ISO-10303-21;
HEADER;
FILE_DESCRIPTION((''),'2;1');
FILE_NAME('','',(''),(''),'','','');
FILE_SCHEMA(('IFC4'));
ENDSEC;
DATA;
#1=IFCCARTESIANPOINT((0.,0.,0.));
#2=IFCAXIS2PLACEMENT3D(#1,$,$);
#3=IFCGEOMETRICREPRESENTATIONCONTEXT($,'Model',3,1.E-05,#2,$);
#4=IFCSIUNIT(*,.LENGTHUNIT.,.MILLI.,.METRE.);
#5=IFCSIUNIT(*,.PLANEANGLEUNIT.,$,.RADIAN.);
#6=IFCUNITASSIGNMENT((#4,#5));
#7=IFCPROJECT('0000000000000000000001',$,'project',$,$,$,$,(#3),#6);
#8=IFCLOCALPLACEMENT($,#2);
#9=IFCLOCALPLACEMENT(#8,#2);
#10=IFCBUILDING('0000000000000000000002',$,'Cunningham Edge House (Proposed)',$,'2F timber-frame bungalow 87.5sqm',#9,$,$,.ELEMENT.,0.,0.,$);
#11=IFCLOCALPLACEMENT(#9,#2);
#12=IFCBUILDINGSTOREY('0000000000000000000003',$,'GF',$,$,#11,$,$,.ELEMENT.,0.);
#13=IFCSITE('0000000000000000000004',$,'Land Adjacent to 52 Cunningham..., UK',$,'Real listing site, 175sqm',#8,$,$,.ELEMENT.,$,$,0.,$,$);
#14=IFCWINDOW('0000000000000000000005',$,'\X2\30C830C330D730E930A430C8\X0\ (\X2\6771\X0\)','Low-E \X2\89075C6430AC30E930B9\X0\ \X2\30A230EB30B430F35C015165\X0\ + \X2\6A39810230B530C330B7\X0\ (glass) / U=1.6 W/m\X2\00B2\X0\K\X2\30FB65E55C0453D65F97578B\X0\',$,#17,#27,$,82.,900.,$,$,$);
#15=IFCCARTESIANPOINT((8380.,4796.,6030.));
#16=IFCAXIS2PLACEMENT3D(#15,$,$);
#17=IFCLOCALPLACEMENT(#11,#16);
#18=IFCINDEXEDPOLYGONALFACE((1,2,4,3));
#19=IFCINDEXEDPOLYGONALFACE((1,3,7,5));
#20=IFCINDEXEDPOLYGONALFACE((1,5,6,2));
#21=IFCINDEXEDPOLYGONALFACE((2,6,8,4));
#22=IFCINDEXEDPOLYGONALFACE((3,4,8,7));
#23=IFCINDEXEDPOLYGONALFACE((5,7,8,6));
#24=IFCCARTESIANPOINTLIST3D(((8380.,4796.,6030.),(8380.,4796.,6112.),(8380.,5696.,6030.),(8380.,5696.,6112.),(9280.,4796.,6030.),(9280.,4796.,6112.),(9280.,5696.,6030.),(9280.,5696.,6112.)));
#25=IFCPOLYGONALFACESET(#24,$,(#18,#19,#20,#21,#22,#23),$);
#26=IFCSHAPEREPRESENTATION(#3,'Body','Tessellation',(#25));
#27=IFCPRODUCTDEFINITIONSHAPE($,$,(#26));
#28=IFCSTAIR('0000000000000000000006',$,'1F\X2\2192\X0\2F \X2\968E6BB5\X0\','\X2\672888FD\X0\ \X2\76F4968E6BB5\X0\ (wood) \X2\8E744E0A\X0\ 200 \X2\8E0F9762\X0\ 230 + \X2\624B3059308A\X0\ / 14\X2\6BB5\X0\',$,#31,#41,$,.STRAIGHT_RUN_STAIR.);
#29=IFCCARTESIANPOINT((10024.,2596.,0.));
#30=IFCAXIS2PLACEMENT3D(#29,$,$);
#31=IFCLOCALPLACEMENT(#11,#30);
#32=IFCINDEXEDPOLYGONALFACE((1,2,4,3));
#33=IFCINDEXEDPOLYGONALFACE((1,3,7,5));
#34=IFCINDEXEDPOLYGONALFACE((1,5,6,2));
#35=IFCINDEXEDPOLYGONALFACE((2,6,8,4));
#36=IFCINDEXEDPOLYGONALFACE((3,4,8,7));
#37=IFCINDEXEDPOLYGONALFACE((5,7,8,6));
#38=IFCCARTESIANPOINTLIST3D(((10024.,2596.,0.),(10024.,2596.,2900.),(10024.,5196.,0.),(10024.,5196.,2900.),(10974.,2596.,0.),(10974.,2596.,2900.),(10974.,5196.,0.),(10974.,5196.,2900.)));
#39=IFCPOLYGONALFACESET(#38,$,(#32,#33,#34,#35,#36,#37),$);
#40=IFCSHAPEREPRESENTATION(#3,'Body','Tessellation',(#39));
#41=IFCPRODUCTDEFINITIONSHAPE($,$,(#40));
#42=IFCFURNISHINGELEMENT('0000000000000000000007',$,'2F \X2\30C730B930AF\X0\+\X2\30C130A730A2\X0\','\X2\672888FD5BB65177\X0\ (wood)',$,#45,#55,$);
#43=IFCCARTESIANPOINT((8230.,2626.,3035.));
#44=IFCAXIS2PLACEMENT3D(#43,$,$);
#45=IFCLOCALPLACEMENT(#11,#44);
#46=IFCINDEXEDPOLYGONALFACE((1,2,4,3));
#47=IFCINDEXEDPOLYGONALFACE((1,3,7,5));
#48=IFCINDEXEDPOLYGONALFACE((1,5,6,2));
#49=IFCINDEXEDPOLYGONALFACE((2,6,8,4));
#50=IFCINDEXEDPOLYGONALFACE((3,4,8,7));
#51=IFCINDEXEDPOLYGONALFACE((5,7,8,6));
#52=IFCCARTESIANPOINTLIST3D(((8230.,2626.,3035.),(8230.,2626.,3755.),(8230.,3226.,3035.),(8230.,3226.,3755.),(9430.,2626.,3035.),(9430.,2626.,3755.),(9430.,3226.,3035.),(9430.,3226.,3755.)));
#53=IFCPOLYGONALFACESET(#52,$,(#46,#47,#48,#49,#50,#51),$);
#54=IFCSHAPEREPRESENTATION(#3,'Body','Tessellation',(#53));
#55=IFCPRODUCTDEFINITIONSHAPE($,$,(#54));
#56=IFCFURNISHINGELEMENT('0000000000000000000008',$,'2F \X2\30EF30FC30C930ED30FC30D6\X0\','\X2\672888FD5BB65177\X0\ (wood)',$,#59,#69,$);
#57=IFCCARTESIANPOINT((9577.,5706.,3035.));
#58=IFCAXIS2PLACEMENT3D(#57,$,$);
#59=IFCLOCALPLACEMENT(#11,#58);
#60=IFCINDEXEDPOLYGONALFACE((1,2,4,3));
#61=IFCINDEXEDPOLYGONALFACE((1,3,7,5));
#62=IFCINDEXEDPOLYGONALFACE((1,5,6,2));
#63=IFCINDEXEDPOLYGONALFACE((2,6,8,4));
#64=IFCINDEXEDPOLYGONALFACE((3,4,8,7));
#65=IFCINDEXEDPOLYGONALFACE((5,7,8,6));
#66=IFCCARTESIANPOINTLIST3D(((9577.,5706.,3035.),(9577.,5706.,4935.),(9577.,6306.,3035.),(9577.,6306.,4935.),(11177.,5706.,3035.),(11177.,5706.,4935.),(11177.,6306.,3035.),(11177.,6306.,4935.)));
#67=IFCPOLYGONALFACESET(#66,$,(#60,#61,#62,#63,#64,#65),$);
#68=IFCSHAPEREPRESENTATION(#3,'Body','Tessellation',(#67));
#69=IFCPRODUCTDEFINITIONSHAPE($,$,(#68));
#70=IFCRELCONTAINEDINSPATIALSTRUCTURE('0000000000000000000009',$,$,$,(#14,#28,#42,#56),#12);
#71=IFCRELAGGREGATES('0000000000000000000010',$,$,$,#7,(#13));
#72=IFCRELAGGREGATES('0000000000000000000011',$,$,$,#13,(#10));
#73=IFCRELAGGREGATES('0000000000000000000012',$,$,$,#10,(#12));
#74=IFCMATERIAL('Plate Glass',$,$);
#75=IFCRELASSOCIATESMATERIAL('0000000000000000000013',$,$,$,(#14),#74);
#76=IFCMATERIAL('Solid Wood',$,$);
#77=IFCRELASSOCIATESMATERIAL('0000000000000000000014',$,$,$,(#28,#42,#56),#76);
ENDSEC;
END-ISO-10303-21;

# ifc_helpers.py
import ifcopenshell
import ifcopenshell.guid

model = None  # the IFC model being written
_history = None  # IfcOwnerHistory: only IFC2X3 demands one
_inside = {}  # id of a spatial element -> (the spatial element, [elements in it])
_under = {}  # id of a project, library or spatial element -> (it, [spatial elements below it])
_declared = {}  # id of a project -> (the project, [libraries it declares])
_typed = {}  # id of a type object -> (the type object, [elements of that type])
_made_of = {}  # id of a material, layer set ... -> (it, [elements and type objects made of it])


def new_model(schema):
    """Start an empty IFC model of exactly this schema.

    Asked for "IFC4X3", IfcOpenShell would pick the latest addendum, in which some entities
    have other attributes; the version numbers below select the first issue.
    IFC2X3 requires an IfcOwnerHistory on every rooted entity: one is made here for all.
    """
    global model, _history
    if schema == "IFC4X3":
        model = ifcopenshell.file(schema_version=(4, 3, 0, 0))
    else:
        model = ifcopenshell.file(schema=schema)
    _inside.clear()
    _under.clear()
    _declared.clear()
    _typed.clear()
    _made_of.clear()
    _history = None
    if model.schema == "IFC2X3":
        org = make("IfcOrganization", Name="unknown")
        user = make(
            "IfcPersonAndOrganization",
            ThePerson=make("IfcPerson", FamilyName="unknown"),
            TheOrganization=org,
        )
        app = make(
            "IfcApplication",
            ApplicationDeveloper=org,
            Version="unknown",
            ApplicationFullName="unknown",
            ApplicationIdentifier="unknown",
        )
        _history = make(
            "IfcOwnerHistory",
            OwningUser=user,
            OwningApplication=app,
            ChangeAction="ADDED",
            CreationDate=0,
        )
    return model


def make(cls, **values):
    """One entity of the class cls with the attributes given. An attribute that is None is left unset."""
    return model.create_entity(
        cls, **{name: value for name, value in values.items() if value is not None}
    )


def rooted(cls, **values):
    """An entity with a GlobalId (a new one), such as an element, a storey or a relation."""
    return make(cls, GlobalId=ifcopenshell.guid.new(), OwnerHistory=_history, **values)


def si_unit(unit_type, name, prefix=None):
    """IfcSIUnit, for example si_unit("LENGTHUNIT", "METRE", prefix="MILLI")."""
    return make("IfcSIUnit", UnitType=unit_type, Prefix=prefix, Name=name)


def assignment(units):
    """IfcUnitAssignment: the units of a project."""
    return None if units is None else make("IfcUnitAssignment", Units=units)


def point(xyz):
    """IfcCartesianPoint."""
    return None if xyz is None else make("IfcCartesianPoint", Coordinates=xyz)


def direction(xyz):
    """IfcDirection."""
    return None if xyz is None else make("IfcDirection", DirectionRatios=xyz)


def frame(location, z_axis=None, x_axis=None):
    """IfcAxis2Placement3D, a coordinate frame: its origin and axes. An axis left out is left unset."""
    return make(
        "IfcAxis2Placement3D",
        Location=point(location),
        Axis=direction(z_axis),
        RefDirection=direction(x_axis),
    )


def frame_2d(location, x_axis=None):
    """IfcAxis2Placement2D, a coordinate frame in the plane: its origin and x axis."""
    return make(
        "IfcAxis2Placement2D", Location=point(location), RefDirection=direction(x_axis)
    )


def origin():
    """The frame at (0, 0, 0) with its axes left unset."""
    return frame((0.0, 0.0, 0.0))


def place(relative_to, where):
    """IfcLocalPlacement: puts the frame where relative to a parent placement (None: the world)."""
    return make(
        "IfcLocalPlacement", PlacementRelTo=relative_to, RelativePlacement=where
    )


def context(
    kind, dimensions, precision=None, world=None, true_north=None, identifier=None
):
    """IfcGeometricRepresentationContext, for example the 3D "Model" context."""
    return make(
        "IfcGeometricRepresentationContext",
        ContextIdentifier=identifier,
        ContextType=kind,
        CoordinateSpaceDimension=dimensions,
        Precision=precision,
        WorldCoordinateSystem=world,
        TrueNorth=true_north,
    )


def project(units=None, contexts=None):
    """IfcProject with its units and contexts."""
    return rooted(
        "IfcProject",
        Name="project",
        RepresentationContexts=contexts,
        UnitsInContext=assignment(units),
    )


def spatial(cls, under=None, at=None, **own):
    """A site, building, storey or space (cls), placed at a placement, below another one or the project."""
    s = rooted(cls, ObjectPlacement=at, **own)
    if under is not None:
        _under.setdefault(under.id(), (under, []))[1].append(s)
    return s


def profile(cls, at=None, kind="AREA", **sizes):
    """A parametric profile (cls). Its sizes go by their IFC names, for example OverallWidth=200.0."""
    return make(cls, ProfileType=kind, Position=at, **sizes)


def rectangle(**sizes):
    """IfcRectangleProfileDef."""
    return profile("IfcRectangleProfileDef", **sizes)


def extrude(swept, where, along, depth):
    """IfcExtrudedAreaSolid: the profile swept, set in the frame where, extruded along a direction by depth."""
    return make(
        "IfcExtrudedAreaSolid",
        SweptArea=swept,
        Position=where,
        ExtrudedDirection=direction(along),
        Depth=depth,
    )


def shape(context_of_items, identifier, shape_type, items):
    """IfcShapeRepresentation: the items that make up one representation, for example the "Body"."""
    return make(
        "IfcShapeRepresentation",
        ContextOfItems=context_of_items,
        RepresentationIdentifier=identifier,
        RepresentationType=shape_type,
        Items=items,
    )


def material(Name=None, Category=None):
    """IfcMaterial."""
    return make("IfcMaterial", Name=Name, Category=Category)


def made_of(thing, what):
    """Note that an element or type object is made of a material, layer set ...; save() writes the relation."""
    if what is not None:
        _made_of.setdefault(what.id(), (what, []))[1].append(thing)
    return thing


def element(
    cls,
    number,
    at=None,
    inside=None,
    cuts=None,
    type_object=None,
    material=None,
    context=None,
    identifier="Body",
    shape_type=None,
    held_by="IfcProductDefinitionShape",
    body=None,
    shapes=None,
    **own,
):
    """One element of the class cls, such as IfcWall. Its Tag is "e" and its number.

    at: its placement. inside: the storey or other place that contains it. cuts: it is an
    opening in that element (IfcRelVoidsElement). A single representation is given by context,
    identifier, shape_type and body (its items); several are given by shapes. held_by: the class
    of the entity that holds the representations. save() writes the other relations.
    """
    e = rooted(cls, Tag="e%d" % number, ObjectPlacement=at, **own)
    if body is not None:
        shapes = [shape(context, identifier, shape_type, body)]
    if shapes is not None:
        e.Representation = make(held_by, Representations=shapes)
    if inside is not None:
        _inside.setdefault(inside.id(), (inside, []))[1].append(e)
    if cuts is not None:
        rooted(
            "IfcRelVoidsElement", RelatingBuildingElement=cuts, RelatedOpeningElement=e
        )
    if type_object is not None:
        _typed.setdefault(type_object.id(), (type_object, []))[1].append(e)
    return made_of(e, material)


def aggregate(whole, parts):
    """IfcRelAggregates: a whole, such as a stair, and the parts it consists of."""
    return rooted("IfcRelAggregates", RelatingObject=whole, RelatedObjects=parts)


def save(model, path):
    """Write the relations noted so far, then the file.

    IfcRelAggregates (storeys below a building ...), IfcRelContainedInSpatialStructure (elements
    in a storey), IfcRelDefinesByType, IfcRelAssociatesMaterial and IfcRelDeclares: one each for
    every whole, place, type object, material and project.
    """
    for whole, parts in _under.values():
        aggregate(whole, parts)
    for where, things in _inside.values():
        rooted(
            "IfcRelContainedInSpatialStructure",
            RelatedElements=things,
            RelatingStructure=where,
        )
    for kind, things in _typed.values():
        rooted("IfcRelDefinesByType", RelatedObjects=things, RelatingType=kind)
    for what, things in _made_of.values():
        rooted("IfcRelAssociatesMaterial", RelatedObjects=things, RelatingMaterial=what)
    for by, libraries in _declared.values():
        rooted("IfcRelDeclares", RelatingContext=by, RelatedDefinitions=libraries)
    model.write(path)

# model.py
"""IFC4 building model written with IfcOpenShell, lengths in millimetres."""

from ifc_helpers import new_model, si_unit, frame, frame_2d, origin, place, context, project, spatial, rectangle, extrude, material, element, save


model = new_model("IFC4")

# Units and contexts
model_context = context("Model", 3, precision=1e-05, world=origin())
ifc_project = project(units=[si_unit("LENGTHUNIT", "METRE", prefix="MILLI"), si_unit("PLANEANGLEUNIT", "RADIAN")], contexts=[model_context])

# Site, building, storey
site_placement = place(None, origin())
site = spatial("IfcSite", under=ifc_project, at=site_placement, Name="Land Adjacent to 52 Cunningham..., UK", ObjectType="Real listing site, 175sqm", CompositionType="ELEMENT", RefElevation=0.0)
building_placement = place(site_placement, origin())
building = spatial("IfcBuilding", under=site, at=building_placement, Name="Cunningham Edge House (Proposed)", ObjectType="2F timber-frame bungalow 87.5sqm", CompositionType="ELEMENT", ElevationOfRefHeight=0.0, ElevationOfTerrain=0.0)
storey_placement = place(building_placement, origin())
storey = spatial("IfcBuildingStorey", under=building, at=storey_placement, Name="GF", CompositionType="ELEMENT", Elevation=0.0)

# Shared definitions
ifc_material_1 = material(Name="Solid Wood")

# Shared definitions
ifc_material_2 = material(Name="Plate Glass")

# Window
window_1_placement = place(storey_placement, frame((8380.0, 4796.0, 6030.0)))
element("IfcWindow", 1, at=window_1_placement, inside=storey, material=ifc_material_2, Name="トップライト (東)", Description="Low-E 複層ガラス アルゴン封入 + 樹脂サッシ (glass) / U=1.6 W/m²K・日射取得型", OverallHeight=82.0, OverallWidth=900.0, context=model_context, shape_type="SweptSolid", body=[
    extrude(rectangle(XDim=900.0, YDim=900.0, at=frame_2d((450.0, 450.0))), frame((8380.0, 4796.0, 6030.0)), (0.0, 0.0, 1.0), 82.0),
])

# Stair
stair_placement = place(storey_placement, frame((10024.0, 2596.0, 0.0)))
element("IfcStair", 2, at=stair_placement, inside=storey, material=ifc_material_1, Name="1F→2F 階段", Description="木製 直階段 (wood) 蹴上 200 踏面 230 + 手すり / 14段", PredefinedType="STRAIGHT_RUN_STAIR", context=model_context, shape_type="SweptSolid", body=[
    extrude(rectangle(XDim=950.0, YDim=2600.0, at=frame_2d((475.0, 1300.0))), frame((10024.0, 2596.0, 0.0)), (0.0, 0.0, 1.0), 2900.0),
])

# Furnishing elements
furnishing_1_placement = place(storey_placement, frame((8230.0, 2626.0, 3035.0)))
element("IfcFurnishingElement", 3, at=furnishing_1_placement, inside=storey, material=ifc_material_1, Name="2F デスク+チェア", Description="木製家具 (wood)", context=model_context, shape_type="SweptSolid", body=[
    extrude(rectangle(XDim=1200.0, YDim=600.0, at=frame_2d((600.0, 300.0))), frame((8230.0, 2626.0, 3035.0)), (0.0, 0.0, 1.0), 720.0),
])
furnishing_2_placement = place(storey_placement, frame((9577.0, 5706.0, 3035.0)))
element("IfcFurnishingElement", 4, at=furnishing_2_placement, inside=storey, material=ifc_material_1, Name="2F ワードローブ", Description="木製家具 (wood)", context=model_context, shape_type="SweptSolid", body=[
    extrude(rectangle(XDim=1600.0, YDim=600.0, at=frame_2d((800.0, 300.0))), frame((9577.0, 5706.0, 3035.0)), (0.0, 0.0, 1.0), 1900.0),
])

save(model, "model.ifc")
